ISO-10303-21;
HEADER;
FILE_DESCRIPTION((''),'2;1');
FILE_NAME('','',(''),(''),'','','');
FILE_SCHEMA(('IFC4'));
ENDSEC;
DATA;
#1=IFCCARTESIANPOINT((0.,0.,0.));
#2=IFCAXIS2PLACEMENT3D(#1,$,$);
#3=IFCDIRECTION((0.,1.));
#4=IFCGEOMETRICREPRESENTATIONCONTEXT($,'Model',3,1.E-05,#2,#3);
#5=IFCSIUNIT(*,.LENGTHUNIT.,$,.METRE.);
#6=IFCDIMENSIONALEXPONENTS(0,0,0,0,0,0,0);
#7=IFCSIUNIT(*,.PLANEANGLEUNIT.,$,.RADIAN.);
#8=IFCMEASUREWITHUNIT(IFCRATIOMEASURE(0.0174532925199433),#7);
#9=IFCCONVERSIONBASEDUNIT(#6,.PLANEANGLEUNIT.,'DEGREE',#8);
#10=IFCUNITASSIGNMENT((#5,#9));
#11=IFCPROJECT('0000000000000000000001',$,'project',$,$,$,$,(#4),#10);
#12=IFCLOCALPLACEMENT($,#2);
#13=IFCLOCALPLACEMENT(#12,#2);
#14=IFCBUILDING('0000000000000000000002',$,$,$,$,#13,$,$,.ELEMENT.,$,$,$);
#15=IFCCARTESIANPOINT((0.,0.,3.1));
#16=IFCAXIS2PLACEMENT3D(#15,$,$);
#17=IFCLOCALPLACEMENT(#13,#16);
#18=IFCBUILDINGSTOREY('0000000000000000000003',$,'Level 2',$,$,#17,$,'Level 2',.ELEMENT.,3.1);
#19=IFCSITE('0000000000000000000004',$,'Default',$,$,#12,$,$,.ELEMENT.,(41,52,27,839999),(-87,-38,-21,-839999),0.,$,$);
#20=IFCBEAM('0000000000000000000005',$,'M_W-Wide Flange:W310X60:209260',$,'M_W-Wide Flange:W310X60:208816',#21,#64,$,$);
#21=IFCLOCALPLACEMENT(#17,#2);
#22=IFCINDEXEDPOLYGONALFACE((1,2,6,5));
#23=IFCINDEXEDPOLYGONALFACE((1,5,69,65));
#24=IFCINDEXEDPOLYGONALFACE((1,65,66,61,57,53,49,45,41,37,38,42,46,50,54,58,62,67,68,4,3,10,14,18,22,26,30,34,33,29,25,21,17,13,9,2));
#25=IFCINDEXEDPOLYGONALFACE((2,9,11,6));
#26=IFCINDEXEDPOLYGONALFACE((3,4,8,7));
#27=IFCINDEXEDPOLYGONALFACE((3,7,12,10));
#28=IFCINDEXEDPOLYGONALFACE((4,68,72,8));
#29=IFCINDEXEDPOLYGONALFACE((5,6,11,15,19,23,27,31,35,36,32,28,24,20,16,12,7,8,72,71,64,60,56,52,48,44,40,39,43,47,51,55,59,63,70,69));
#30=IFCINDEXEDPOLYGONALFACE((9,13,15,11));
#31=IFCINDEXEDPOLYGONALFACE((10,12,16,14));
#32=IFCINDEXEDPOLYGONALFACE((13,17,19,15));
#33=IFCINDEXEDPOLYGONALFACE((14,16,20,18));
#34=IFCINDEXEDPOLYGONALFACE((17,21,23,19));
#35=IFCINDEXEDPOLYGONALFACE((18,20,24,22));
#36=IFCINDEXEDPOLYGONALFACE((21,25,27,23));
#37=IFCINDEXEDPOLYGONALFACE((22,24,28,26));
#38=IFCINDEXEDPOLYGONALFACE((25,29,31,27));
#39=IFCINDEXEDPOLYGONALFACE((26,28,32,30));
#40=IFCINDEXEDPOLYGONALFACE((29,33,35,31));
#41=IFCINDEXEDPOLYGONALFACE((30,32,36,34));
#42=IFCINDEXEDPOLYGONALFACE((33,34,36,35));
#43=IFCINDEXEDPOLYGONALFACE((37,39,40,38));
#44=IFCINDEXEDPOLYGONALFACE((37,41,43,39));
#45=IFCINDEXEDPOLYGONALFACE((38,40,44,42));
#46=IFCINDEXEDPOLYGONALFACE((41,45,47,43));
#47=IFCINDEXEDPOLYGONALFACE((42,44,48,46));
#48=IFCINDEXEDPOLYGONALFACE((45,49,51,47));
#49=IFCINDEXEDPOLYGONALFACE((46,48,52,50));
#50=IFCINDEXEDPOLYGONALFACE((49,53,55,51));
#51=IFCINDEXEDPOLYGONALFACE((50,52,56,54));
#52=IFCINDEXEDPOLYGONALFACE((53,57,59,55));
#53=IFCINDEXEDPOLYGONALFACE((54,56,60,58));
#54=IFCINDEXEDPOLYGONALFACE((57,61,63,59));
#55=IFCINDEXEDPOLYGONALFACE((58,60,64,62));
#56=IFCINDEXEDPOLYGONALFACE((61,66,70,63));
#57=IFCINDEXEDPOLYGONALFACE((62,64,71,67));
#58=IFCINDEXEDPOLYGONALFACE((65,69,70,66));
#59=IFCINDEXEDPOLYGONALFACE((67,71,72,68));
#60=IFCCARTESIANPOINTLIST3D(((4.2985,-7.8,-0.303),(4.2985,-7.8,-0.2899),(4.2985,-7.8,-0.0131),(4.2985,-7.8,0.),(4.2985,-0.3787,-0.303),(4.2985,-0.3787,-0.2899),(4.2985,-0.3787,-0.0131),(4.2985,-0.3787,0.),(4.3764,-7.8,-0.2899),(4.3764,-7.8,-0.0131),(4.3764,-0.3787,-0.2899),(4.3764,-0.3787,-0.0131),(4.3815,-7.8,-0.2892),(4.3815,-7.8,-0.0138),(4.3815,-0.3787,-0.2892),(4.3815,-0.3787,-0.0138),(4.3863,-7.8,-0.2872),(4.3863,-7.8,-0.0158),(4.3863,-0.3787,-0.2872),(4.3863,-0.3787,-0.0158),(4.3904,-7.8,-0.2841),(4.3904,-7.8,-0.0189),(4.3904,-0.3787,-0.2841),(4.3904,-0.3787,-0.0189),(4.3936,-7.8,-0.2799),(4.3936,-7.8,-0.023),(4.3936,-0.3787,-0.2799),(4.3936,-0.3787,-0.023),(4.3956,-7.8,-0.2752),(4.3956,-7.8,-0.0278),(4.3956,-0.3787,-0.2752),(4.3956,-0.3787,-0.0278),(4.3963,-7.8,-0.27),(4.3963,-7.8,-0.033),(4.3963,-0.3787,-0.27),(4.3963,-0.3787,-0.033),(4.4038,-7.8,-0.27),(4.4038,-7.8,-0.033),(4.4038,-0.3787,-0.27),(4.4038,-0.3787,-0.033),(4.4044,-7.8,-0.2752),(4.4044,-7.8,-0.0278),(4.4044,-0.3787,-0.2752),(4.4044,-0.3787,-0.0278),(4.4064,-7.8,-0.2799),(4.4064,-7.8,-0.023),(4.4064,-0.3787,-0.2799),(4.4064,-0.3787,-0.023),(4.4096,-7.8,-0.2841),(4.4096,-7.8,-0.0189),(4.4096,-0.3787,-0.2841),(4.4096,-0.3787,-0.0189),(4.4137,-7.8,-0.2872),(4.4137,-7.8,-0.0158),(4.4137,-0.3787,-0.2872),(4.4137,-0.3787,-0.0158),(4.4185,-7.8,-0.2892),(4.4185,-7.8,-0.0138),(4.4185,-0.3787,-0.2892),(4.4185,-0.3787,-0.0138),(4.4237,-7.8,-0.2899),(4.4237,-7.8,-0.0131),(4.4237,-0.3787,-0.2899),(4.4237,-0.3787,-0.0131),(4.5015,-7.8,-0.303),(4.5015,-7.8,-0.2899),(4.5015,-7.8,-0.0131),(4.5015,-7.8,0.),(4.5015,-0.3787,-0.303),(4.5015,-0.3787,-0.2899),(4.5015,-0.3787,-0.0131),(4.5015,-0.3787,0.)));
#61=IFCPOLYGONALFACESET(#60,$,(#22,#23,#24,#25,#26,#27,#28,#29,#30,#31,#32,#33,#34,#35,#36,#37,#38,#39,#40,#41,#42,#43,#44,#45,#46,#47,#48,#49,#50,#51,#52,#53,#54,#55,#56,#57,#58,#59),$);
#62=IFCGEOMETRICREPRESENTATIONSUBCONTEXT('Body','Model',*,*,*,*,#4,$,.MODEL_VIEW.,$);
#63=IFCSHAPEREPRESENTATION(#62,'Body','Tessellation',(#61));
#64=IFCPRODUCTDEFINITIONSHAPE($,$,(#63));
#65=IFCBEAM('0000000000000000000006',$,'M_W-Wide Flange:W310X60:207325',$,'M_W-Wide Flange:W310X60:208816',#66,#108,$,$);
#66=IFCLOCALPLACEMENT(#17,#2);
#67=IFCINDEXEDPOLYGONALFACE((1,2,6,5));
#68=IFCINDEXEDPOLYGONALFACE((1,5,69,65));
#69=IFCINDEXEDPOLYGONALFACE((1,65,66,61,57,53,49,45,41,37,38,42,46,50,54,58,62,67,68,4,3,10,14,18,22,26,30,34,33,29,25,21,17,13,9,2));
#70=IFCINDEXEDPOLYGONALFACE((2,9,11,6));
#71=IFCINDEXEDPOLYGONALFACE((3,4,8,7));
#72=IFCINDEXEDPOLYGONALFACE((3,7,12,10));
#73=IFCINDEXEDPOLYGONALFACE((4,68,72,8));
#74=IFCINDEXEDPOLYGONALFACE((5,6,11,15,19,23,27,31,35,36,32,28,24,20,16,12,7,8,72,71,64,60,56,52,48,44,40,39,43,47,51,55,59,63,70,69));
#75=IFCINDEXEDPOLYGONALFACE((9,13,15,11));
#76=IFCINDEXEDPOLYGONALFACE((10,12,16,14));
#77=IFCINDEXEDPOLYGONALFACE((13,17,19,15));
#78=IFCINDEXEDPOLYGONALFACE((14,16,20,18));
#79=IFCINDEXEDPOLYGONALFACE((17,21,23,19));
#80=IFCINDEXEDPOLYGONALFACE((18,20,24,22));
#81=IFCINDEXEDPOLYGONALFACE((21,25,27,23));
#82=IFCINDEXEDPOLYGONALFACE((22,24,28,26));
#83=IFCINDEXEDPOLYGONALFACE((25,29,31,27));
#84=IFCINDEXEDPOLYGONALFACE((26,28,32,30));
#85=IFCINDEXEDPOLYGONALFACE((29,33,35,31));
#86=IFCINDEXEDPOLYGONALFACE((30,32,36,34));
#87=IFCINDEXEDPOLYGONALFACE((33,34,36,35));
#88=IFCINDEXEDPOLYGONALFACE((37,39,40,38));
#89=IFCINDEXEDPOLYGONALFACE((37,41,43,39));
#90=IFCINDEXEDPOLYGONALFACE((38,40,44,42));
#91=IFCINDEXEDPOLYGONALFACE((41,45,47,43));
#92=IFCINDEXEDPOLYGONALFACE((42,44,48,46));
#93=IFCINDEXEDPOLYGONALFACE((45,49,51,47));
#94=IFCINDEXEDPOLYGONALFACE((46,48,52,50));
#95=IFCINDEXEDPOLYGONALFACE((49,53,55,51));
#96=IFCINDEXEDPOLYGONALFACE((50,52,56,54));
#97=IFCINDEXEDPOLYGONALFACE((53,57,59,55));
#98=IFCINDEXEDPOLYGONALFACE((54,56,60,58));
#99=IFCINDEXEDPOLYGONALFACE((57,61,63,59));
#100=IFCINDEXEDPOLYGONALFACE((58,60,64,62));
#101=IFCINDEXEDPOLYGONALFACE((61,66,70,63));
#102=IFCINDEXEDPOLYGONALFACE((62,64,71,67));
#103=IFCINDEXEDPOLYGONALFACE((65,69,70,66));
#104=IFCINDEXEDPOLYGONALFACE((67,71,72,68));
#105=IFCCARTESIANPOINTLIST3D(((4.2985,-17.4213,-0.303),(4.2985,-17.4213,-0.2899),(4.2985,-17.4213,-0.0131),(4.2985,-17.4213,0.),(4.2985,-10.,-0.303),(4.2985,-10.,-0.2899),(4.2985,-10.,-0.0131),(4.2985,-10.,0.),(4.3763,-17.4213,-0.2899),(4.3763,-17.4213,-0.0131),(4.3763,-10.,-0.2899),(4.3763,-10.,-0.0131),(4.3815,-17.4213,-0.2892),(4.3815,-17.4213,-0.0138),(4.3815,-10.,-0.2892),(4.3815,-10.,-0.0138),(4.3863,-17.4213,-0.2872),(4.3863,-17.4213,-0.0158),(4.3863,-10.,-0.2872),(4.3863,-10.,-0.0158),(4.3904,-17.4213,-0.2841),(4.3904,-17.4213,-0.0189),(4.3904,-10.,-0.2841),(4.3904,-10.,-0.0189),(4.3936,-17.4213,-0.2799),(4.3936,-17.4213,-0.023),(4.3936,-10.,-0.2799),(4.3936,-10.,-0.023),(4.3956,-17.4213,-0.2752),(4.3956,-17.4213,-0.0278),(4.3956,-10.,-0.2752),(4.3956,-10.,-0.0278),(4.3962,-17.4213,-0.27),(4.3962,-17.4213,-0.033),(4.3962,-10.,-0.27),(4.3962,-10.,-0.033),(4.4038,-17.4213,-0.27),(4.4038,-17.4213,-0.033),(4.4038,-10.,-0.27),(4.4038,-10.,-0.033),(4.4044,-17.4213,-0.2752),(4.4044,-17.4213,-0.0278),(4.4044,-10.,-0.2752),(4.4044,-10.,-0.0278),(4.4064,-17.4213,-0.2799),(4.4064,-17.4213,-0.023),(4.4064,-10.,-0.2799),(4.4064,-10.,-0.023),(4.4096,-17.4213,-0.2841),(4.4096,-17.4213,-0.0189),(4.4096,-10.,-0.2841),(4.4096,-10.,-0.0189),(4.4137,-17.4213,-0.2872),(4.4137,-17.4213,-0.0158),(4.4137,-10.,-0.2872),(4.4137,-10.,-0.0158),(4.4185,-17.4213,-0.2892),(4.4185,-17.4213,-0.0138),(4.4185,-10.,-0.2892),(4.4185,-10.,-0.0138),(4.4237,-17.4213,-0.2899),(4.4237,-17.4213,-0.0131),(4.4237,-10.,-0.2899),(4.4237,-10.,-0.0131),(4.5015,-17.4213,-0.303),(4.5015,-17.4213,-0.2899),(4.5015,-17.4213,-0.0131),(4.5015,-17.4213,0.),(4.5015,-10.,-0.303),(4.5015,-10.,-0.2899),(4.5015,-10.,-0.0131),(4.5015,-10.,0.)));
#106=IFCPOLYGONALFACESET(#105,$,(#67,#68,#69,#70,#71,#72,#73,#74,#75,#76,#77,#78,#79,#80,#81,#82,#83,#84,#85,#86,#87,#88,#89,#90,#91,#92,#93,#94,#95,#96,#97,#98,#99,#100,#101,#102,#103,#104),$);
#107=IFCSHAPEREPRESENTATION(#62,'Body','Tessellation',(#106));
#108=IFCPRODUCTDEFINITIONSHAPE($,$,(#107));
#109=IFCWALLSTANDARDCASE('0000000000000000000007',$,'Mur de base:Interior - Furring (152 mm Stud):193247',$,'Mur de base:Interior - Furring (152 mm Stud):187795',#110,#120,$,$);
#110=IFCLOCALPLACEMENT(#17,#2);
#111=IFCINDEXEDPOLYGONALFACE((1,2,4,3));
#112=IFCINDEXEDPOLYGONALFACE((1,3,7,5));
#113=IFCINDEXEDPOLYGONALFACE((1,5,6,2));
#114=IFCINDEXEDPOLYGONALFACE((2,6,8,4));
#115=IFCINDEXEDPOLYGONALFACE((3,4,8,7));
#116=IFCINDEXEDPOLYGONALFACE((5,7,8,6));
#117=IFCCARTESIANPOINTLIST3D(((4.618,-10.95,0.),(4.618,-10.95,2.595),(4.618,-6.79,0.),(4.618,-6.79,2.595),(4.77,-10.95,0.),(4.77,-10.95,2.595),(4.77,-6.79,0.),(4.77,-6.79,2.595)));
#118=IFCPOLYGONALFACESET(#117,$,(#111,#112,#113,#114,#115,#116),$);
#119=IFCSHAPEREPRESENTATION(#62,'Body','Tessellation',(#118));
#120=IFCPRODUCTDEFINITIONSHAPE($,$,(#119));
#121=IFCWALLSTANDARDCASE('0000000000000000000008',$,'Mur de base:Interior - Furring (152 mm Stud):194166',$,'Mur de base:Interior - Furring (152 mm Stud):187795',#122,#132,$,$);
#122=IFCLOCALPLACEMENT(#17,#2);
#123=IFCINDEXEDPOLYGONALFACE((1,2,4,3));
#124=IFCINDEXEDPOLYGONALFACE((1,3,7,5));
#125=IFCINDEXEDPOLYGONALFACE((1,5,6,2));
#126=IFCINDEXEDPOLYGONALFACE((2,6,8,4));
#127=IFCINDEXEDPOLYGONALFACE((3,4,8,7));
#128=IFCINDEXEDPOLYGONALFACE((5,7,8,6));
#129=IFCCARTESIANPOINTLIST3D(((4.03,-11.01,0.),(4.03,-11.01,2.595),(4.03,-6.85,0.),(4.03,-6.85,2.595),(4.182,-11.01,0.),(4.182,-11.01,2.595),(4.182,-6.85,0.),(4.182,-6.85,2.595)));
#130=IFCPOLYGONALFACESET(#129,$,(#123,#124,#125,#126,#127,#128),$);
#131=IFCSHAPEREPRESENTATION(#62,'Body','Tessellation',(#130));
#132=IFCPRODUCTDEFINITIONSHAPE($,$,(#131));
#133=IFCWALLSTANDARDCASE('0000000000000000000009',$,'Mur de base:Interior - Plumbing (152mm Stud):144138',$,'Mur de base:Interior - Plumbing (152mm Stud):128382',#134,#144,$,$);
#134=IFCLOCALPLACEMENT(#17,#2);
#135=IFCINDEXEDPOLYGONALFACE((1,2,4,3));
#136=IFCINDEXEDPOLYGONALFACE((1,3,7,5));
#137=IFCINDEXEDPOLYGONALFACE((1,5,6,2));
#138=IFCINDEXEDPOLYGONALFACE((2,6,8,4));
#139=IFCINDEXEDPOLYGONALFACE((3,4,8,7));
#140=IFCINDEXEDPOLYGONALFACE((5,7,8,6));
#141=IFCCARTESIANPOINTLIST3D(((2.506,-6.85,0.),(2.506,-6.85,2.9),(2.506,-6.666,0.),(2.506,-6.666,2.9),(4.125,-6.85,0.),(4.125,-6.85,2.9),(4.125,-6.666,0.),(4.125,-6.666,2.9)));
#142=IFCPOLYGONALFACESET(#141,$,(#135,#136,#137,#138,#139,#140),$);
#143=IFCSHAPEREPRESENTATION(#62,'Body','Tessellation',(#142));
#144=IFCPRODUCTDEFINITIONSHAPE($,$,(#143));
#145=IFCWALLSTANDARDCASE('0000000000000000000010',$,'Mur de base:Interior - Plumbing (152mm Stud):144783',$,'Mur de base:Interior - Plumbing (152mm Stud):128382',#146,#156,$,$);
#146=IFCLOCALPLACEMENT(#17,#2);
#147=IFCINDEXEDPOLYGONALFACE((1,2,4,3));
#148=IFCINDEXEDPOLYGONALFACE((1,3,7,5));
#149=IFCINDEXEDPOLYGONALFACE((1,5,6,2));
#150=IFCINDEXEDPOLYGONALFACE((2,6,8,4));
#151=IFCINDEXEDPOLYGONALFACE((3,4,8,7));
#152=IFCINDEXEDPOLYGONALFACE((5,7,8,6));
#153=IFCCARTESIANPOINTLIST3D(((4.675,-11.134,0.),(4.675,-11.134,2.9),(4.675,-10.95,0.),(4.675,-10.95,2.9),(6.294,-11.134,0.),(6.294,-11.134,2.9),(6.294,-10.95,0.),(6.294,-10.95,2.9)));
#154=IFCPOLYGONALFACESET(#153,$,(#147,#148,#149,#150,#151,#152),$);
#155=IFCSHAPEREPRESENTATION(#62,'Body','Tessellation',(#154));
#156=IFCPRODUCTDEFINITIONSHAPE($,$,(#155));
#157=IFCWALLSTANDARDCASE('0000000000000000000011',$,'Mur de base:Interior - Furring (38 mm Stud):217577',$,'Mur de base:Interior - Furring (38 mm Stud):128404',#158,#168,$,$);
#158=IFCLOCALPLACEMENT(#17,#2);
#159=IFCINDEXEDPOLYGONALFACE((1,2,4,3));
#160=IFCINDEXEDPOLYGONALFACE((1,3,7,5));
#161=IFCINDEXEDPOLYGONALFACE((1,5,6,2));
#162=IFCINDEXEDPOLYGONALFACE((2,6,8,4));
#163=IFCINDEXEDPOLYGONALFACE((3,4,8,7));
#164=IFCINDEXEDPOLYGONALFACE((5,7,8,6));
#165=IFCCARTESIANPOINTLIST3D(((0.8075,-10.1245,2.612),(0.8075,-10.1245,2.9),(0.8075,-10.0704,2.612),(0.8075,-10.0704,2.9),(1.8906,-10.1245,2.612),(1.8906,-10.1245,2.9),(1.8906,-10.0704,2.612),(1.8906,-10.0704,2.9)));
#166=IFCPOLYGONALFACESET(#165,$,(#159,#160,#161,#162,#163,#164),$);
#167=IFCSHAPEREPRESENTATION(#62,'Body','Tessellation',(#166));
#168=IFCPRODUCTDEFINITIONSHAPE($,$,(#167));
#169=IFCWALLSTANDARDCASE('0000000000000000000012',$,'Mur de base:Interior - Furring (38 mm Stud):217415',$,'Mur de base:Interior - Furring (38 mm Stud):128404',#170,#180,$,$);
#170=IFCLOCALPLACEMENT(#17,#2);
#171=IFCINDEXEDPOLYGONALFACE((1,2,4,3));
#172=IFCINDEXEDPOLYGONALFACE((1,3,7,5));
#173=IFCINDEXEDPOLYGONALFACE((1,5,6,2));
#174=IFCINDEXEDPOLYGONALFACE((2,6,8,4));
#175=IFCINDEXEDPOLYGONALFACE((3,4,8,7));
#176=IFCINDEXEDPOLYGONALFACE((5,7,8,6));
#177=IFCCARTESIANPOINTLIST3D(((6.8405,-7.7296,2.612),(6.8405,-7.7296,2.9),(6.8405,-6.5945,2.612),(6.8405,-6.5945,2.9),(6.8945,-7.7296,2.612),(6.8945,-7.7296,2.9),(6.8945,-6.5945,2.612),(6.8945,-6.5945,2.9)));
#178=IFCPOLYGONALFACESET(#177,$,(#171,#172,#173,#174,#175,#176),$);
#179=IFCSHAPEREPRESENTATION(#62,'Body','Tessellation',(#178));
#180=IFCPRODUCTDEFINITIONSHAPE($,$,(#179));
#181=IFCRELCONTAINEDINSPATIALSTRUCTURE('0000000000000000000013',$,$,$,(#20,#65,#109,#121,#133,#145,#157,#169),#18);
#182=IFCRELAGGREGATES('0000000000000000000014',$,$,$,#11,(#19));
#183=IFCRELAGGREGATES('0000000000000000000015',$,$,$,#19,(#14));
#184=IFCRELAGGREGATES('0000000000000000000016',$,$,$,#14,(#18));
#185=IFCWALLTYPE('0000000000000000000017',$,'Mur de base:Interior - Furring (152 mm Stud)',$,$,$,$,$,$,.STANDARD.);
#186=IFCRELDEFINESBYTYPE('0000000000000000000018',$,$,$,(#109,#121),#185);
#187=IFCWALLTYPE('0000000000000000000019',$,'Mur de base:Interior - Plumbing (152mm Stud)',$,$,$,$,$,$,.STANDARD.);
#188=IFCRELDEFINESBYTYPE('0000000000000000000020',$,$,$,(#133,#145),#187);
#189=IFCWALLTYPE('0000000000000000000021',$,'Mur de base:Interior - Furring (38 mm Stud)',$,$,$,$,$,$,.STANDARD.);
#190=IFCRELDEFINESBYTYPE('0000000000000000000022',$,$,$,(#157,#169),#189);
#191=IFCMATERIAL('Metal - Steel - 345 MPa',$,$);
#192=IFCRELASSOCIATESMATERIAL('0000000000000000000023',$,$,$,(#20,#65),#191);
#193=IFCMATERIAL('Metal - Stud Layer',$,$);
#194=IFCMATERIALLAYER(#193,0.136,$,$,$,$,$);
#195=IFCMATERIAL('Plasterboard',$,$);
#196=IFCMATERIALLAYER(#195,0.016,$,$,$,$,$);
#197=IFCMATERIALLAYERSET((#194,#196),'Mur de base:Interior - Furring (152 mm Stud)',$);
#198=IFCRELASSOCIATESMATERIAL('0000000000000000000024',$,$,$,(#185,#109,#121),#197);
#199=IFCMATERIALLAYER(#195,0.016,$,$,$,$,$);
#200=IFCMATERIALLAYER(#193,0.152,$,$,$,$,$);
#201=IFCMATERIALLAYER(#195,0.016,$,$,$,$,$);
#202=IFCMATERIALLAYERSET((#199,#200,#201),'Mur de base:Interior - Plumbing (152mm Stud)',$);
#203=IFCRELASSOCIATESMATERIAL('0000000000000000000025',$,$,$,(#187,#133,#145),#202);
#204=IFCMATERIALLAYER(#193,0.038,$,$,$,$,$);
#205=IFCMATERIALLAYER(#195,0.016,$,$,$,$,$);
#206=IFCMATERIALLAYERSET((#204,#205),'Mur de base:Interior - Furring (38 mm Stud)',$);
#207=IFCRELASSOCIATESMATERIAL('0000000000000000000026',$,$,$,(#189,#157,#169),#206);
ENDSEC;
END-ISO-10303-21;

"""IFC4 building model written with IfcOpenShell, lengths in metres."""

from ifc_helpers import new_model, entity, si_unit, converted_unit, direction, frame, frame_2d, origin, place, context, subcontext, project, spatial, rectangle, i_section, extrude, material, layer, layer_set, layer_usage, type_object, element, save


model = new_model("IFC4")

# Units and contexts
model_context = context("Model", 3, precision=1e-05, world=origin(), true_north=direction((0.0, 1.0)))
body_context = subcontext(model_context, "Body", "Model", "MODEL_VIEW")
ifc_project = project(units=[si_unit("LENGTHUNIT", "METRE"), converted_unit("PLANEANGLEUNIT", "DEGREE", entity("IfcRatioMeasure", 0.0174532925199433), si_unit("PLANEANGLEUNIT", "RADIAN"), dimensions=[0, 0, 0, 0, 0, 0, 0])], contexts=[model_context])

# Site, building, storey
site_placement = place(None, origin())
site = spatial("IfcSite", under=ifc_project, at=site_placement, Name="Default", CompositionType="ELEMENT", RefLatitude=(41, 52, 27, 839999), RefLongitude=(-87, -38, -21, -839999), RefElevation=0.0)
building_placement = place(site_placement, origin())
building = spatial("IfcBuilding", under=site, at=building_placement, CompositionType="ELEMENT")
storey_placement = place(building_placement, frame((0.0, 0.0, 3.1)))
storey = spatial("IfcBuildingStorey", under=building, at=storey_placement, Name="Level 2", LongName="Level 2", CompositionType="ELEMENT", Elevation=3.1)

# Beams
ifc_material_1 = material(Name="Metal - Steel - 345 MPa")
beam_1_placement = place(storey_placement, frame((4.4, -7.8, 0.0), z_axis=(0.0, 0.0, 1.0), x_axis=(0.0, 1.0, 0.0)))
element("IfcBeam", 1, at=beam_1_placement, inside=storey, material=ifc_material_1, Name="M_W-Wide Flange:W310X60:209260", ObjectType="M_W-Wide Flange:W310X60:208816", context=body_context, shape_type="SweptSolid", body=[
    extrude(i_section(OverallWidth=0.203, OverallDepth=0.303, WebThickness=0.0075, FlangeThickness=0.0131, FilletRadius=0.0199, at=frame_2d((0.0, 0.0), x_axis=(0.0, 1.0))), frame((0.0, 0.0, -0.1515), z_axis=(1.0, 0.0, 0.0), x_axis=(0.0, 0.0, -1.0)), (0.0, 0.0, 1.0), 7.4213),
])
beam_2_placement = place(storey_placement, frame((4.4, -10.0, 0.0), z_axis=(0.0, 0.0, 1.0), x_axis=(0.0, -1.0, 0.0)))
element("IfcBeam", 2, at=beam_2_placement, inside=storey, material=ifc_material_1, Name="M_W-Wide Flange:W310X60:207325", ObjectType="M_W-Wide Flange:W310X60:208816", context=body_context, shape_type="SweptSolid", body=[
    extrude(i_section(OverallWidth=0.203, OverallDepth=0.303, WebThickness=0.0075, FlangeThickness=0.0131, FilletRadius=0.0199, at=frame_2d((0.0, 0.0), x_axis=(0.0, 1.0))), frame((0.0, 0.0, -0.1515), z_axis=(1.0, 0.0, 0.0), x_axis=(0.0, 0.0, -1.0)), (0.0, 0.0, 1.0), 7.4213),
])

# Walls
ifc_material_2 = material(Name="Metal - Stud Layer")
ifc_layer_1 = layer(ifc_material_2, 0.136)
ifc_material_3 = material(Name="Plasterboard")
ifc_layer_2 = layer(ifc_material_3, 0.016)
ifc_layer_set_1 = layer_set([ifc_layer_1, ifc_layer_2], Name="Mur de base:Interior - Furring (152 mm Stud)")
ifc_layer_usage_1 = layer_usage(ifc_layer_set_1, "AXIS2", "POSITIVE", -0.076)
wall_type_1 = type_object("IfcWallType", Name="Mur de base:Interior - Furring (152 mm Stud)", PredefinedType="STANDARD", material=ifc_layer_set_1)
wall_1_placement = place(storey_placement, frame((4.694, -6.79, 0.0), z_axis=(0.0, 0.0, 1.0), x_axis=(0.0, -1.0, 0.0)))
element("IfcWallStandardCase", 3, at=wall_1_placement, inside=storey, type_object=wall_type_1, material=ifc_layer_usage_1, Name="Mur de base:Interior - Furring (152 mm Stud):193247", ObjectType="Mur de base:Interior - Furring (152 mm Stud):187795", context=body_context, shape_type="SweptSolid", body=[
    extrude(rectangle(XDim=4.16, YDim=0.152, at=frame_2d((2.08, 0.0), x_axis=(-1.0, 0.0))), origin(), (0.0, 0.0, 1.0), 2.595),
])
ifc_layer_usage_2 = layer_usage(ifc_layer_set_1, "AXIS2", "POSITIVE", -0.076)
wall_2_placement = place(storey_placement, frame((4.106, -11.01, 0.0), z_axis=(0.0, 0.0, 1.0), x_axis=(0.0, 1.0, 0.0)))
element("IfcWallStandardCase", 4, at=wall_2_placement, inside=storey, type_object=wall_type_1, material=ifc_layer_usage_2, Name="Mur de base:Interior - Furring (152 mm Stud):194166", ObjectType="Mur de base:Interior - Furring (152 mm Stud):187795", context=body_context, shape_type="SweptSolid", body=[
    extrude(rectangle(XDim=4.16, YDim=0.152, at=frame_2d((2.08, 0.0), x_axis=(-1.0, 0.0))), origin(), (0.0, 0.0, 1.0), 2.595),
])
ifc_layer_3 = layer(ifc_material_3, 0.016)
ifc_layer_4 = layer(ifc_material_2, 0.152)
ifc_layer_5 = layer(ifc_material_3, 0.016)
ifc_layer_set_2 = layer_set([ifc_layer_3, ifc_layer_4, ifc_layer_5], Name="Mur de base:Interior - Plumbing (152mm Stud)")
ifc_layer_usage_3 = layer_usage(ifc_layer_set_2, "AXIS2", "NEGATIVE", 0.092)
wall_type_2 = type_object("IfcWallType", Name="Mur de base:Interior - Plumbing (152mm Stud)", PredefinedType="STANDARD", material=ifc_layer_set_2)
wall_3_placement = place(storey_placement, frame((2.506, -6.758, 0.0)))
element("IfcWallStandardCase", 5, at=wall_3_placement, inside=storey, type_object=wall_type_2, material=ifc_layer_usage_3, Name="Mur de base:Interior - Plumbing (152mm Stud):144138", ObjectType="Mur de base:Interior - Plumbing (152mm Stud):128382", context=body_context, shape_type="SweptSolid", body=[
    extrude(rectangle(XDim=1.619, YDim=0.184, at=frame_2d((0.8095, 0.0), x_axis=(-1.0, 0.0))), origin(), (0.0, 0.0, 1.0), 2.9),
])
ifc_layer_usage_4 = layer_usage(ifc_layer_set_2, "AXIS2", "NEGATIVE", 0.092)
wall_4_placement = place(storey_placement, frame((6.294, -11.042, 0.0), z_axis=(0.0, 0.0, 1.0), x_axis=(-1.0, 0.0, 0.0)))
element("IfcWallStandardCase", 6, at=wall_4_placement, inside=storey, type_object=wall_type_2, material=ifc_layer_usage_4, Name="Mur de base:Interior - Plumbing (152mm Stud):144783", ObjectType="Mur de base:Interior - Plumbing (152mm Stud):128382", context=body_context, shape_type="SweptSolid", body=[
    extrude(rectangle(XDim=1.619, YDim=0.184, at=frame_2d((0.8095, 0.0), x_axis=(-1.0, 0.0))), origin(), (0.0, 0.0, 1.0), 2.9),
])
ifc_layer_6 = layer(ifc_material_2, 0.038)
ifc_layer_7 = layer(ifc_material_3, 0.016)
ifc_layer_set_3 = layer_set([ifc_layer_6, ifc_layer_7], Name="Mur de base:Interior - Furring (38 mm Stud)")
ifc_layer_usage_5 = layer_usage(ifc_layer_set_3, "AXIS2", "NEGATIVE", 0.027)
wall_type_3 = type_object("IfcWallType", Name="Mur de base:Interior - Furring (38 mm Stud)", PredefinedType="STANDARD", material=ifc_layer_set_3)
wall_5_placement = place(storey_placement, frame((0.8075, -10.0975, 2.612)))
element("IfcWallStandardCase", 7, at=wall_5_placement, inside=storey, type_object=wall_type_3, material=ifc_layer_usage_5, Name="Mur de base:Interior - Furring (38 mm Stud):217577", ObjectType="Mur de base:Interior - Furring (38 mm Stud):128404", context=body_context, shape_type="SweptSolid", body=[
    extrude(rectangle(XDim=1.0831, YDim=0.054, at=frame_2d((0.5415, 0.0), x_axis=(-1.0, 0.0))), origin(), (0.0, 0.0, 1.0), 0.288),
])
ifc_layer_usage_6 = layer_usage(ifc_layer_set_3, "AXIS2", "NEGATIVE", 0.027)
wall_6_placement = place(storey_placement, frame((6.8675, -7.7296, 2.612), z_axis=(0.0, 0.0, 1.0), x_axis=(0.0, 1.0, 0.0)))
element("IfcWallStandardCase", 8, at=wall_6_placement, inside=storey, type_object=wall_type_3, material=ifc_layer_usage_6, Name="Mur de base:Interior - Furring (38 mm Stud):217415", ObjectType="Mur de base:Interior - Furring (38 mm Stud):128404", context=body_context, shape_type="SweptSolid", body=[
    extrude(rectangle(XDim=1.1351, YDim=0.054, at=frame_2d((0.5675, 0.0), x_axis=(-1.0, 0.0))), origin(), (0.0, 0.0, 1.0), 0.288),
])

save(model, "model.ifc")
